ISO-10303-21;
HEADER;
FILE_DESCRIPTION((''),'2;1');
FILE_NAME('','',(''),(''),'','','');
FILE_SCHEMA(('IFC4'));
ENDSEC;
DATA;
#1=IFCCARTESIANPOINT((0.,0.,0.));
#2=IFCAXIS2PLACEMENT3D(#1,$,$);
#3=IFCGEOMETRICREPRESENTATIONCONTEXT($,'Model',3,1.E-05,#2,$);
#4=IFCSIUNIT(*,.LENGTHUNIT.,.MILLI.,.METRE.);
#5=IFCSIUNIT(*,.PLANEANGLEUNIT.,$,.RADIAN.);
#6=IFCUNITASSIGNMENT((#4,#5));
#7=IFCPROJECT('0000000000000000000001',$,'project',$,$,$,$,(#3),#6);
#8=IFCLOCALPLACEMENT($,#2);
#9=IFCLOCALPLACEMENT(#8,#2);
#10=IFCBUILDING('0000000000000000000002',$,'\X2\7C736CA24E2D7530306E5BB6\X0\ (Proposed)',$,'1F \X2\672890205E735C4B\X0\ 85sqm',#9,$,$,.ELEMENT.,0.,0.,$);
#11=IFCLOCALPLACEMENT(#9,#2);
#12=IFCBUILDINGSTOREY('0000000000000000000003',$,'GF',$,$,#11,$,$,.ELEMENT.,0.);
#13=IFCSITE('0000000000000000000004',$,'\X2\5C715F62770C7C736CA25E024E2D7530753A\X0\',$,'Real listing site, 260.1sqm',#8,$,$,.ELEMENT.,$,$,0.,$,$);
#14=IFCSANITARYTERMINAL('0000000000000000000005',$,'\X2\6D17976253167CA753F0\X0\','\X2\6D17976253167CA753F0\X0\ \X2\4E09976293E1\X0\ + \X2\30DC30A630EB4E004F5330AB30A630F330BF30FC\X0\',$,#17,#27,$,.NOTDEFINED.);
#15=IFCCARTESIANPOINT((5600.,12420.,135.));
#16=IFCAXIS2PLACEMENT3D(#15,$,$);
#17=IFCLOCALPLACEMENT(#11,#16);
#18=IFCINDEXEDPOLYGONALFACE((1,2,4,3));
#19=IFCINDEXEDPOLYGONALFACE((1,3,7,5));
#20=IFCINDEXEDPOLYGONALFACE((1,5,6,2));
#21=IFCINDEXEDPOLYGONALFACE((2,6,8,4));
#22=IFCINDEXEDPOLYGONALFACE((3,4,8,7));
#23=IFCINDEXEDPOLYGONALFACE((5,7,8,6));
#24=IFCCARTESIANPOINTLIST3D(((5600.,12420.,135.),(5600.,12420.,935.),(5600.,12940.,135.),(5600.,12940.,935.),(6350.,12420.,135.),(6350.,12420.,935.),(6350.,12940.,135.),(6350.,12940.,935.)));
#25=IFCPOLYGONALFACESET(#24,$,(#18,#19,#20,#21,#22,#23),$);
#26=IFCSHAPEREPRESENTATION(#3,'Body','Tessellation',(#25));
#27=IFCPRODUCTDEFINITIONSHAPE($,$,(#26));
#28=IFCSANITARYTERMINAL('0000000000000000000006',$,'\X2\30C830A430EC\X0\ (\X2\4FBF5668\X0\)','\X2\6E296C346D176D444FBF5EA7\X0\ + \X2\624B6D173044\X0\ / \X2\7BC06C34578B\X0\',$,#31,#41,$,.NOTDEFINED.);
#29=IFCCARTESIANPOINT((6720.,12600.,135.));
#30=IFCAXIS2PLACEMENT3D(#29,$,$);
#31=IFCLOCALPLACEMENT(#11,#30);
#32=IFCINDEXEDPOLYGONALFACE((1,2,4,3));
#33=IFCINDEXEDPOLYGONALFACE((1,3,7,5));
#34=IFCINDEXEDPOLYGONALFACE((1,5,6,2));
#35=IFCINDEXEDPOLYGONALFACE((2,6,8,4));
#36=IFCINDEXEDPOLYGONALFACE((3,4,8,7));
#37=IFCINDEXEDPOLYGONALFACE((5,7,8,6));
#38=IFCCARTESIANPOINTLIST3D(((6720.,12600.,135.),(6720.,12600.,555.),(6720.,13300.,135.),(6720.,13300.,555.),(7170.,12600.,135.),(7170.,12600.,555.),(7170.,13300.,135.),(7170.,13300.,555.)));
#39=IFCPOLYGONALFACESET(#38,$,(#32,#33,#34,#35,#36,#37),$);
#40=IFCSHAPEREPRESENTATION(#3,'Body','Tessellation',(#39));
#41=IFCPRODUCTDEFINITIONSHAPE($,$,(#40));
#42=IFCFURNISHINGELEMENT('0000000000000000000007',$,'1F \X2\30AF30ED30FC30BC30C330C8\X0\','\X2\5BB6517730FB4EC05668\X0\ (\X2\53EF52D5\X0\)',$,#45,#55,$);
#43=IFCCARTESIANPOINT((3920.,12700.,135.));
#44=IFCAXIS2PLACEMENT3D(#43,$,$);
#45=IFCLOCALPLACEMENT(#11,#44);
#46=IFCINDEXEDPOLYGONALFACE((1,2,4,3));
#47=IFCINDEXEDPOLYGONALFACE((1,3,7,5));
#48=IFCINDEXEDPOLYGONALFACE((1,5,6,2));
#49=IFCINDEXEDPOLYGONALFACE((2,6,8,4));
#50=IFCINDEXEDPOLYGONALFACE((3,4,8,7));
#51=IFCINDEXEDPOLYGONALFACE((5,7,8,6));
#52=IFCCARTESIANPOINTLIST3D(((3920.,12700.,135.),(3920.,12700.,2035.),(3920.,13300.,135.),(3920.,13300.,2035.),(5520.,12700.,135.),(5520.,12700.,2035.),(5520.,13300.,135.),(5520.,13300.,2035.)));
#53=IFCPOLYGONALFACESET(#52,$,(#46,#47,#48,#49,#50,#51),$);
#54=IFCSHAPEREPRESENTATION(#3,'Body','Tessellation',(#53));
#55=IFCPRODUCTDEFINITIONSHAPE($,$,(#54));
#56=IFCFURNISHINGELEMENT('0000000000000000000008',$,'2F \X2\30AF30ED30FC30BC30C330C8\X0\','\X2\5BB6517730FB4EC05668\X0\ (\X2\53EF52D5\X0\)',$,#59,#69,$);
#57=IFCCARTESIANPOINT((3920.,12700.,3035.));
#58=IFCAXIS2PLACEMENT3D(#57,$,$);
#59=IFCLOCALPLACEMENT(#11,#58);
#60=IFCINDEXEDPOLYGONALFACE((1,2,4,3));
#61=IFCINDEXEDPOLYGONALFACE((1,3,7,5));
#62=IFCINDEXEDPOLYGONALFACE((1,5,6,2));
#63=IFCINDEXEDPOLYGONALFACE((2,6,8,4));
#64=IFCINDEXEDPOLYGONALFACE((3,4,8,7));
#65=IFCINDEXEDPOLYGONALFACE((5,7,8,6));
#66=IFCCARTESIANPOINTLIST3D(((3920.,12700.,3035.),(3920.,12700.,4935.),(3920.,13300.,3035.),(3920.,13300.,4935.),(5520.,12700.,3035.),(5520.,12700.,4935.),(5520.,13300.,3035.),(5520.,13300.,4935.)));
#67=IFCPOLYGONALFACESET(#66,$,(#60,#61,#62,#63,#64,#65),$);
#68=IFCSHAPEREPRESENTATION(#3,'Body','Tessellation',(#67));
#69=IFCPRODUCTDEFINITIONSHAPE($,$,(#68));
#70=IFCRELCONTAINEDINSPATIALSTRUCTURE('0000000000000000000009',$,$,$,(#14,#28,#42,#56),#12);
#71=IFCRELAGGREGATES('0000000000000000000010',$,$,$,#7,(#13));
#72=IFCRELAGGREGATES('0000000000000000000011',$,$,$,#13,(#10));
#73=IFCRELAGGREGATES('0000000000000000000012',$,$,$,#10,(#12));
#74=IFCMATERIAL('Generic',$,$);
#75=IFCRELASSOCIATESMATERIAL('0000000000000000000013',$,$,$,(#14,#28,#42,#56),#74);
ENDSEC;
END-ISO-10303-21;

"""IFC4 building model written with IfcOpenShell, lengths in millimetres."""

from ifc_helpers import new_model, si_unit, frame, frame_2d, origin, place, context, project, spatial, rectangle, extrude, material, element, save


model = new_model("IFC4")

# Units and contexts
model_context = context("Model", 3, precision=1e-05, world=origin())
ifc_project = project(units=[si_unit("LENGTHUNIT", "METRE", prefix="MILLI"), si_unit("PLANEANGLEUNIT", "RADIAN")], contexts=[model_context])

# Site, building, storey
site_placement = place(None, origin())
site = spatial("IfcSite", under=ifc_project, at=site_placement, Name="山形県米沢市中田町", ObjectType="Real listing site, 260.1sqm", CompositionType="ELEMENT", RefElevation=0.0)
building_placement = place(site_placement, origin())
building = spatial("IfcBuilding", under=site, at=building_placement, Name="米沢中田の家 (Proposed)", ObjectType="1F 木造平屋 85sqm", CompositionType="ELEMENT", ElevationOfRefHeight=0.0, ElevationOfTerrain=0.0)
storey_placement = place(building_placement, origin())
storey = spatial("IfcBuildingStorey", under=building, at=storey_placement, Name="GF", CompositionType="ELEMENT", Elevation=0.0)

# Shared definitions
ifc_material_1 = material(Name="Generic")

# Sanitary terminals
sanitary_terminal_1_placement = place(storey_placement, frame((5600.0, 12420.0, 135.0)))
element("IfcSanitaryTerminal", 1, at=sanitary_terminal_1_placement, inside=storey, material=ifc_material_1, Name="洗面化粧台", Description="洗面化粧台 三面鏡 + ボウル一体カウンター", PredefinedType="NOTDEFINED", context=model_context, shape_type="SweptSolid", body=[
    extrude(rectangle(XDim=750.0, YDim=520.0, at=frame_2d((375.0, 260.0))), frame((5600.0, 12420.0, 135.0)), (0.0, 0.0, 1.0), 800.0),
])
sanitary_terminal_2_placement = place(storey_placement, frame((6720.0, 12600.0, 135.0)))
element("IfcSanitaryTerminal", 2, at=sanitary_terminal_2_placement, inside=storey, material=ifc_material_1, Name="トイレ (便器)", Description="温水洗浄便座 + 手洗い / 節水型", PredefinedType="NOTDEFINED", context=model_context, shape_type="SweptSolid", body=[
    extrude(rectangle(XDim=450.0, YDim=700.0, at=frame_2d((225.0, 350.0))), frame((6720.0, 12600.0, 135.0)), (0.0, 0.0, 1.0), 420.0),
])

# Furnishing elements
furnishing_1_placement = place(storey_placement, frame((3920.0, 12700.0, 135.0)))
element("IfcFurnishingElement", 3, at=furnishing_1_placement, inside=storey, material=ifc_material_1, Name="1F クローゼット", Description="家具・什器 (可動)", context=model_context, shape_type="SweptSolid", body=[
    extrude(rectangle(XDim=1600.0, YDim=600.0, at=frame_2d((800.0, 300.0))), frame((3920.0, 12700.0, 135.0)), (0.0, 0.0, 1.0), 1900.0),
])
furnishing_2_placement = place(storey_placement, frame((3920.0, 12700.0, 3035.0)))
element("IfcFurnishingElement", 4, at=furnishing_2_placement, inside=storey, material=ifc_material_1, Name="2F クローゼット", Description="家具・什器 (可動)", context=model_context, shape_type="SweptSolid", body=[
    extrude(rectangle(XDim=1600.0, YDim=600.0, at=frame_2d((800.0, 300.0))), frame((3920.0, 12700.0, 3035.0)), (0.0, 0.0, 1.0), 1900.0),
])

save(model, "model.ifc")
